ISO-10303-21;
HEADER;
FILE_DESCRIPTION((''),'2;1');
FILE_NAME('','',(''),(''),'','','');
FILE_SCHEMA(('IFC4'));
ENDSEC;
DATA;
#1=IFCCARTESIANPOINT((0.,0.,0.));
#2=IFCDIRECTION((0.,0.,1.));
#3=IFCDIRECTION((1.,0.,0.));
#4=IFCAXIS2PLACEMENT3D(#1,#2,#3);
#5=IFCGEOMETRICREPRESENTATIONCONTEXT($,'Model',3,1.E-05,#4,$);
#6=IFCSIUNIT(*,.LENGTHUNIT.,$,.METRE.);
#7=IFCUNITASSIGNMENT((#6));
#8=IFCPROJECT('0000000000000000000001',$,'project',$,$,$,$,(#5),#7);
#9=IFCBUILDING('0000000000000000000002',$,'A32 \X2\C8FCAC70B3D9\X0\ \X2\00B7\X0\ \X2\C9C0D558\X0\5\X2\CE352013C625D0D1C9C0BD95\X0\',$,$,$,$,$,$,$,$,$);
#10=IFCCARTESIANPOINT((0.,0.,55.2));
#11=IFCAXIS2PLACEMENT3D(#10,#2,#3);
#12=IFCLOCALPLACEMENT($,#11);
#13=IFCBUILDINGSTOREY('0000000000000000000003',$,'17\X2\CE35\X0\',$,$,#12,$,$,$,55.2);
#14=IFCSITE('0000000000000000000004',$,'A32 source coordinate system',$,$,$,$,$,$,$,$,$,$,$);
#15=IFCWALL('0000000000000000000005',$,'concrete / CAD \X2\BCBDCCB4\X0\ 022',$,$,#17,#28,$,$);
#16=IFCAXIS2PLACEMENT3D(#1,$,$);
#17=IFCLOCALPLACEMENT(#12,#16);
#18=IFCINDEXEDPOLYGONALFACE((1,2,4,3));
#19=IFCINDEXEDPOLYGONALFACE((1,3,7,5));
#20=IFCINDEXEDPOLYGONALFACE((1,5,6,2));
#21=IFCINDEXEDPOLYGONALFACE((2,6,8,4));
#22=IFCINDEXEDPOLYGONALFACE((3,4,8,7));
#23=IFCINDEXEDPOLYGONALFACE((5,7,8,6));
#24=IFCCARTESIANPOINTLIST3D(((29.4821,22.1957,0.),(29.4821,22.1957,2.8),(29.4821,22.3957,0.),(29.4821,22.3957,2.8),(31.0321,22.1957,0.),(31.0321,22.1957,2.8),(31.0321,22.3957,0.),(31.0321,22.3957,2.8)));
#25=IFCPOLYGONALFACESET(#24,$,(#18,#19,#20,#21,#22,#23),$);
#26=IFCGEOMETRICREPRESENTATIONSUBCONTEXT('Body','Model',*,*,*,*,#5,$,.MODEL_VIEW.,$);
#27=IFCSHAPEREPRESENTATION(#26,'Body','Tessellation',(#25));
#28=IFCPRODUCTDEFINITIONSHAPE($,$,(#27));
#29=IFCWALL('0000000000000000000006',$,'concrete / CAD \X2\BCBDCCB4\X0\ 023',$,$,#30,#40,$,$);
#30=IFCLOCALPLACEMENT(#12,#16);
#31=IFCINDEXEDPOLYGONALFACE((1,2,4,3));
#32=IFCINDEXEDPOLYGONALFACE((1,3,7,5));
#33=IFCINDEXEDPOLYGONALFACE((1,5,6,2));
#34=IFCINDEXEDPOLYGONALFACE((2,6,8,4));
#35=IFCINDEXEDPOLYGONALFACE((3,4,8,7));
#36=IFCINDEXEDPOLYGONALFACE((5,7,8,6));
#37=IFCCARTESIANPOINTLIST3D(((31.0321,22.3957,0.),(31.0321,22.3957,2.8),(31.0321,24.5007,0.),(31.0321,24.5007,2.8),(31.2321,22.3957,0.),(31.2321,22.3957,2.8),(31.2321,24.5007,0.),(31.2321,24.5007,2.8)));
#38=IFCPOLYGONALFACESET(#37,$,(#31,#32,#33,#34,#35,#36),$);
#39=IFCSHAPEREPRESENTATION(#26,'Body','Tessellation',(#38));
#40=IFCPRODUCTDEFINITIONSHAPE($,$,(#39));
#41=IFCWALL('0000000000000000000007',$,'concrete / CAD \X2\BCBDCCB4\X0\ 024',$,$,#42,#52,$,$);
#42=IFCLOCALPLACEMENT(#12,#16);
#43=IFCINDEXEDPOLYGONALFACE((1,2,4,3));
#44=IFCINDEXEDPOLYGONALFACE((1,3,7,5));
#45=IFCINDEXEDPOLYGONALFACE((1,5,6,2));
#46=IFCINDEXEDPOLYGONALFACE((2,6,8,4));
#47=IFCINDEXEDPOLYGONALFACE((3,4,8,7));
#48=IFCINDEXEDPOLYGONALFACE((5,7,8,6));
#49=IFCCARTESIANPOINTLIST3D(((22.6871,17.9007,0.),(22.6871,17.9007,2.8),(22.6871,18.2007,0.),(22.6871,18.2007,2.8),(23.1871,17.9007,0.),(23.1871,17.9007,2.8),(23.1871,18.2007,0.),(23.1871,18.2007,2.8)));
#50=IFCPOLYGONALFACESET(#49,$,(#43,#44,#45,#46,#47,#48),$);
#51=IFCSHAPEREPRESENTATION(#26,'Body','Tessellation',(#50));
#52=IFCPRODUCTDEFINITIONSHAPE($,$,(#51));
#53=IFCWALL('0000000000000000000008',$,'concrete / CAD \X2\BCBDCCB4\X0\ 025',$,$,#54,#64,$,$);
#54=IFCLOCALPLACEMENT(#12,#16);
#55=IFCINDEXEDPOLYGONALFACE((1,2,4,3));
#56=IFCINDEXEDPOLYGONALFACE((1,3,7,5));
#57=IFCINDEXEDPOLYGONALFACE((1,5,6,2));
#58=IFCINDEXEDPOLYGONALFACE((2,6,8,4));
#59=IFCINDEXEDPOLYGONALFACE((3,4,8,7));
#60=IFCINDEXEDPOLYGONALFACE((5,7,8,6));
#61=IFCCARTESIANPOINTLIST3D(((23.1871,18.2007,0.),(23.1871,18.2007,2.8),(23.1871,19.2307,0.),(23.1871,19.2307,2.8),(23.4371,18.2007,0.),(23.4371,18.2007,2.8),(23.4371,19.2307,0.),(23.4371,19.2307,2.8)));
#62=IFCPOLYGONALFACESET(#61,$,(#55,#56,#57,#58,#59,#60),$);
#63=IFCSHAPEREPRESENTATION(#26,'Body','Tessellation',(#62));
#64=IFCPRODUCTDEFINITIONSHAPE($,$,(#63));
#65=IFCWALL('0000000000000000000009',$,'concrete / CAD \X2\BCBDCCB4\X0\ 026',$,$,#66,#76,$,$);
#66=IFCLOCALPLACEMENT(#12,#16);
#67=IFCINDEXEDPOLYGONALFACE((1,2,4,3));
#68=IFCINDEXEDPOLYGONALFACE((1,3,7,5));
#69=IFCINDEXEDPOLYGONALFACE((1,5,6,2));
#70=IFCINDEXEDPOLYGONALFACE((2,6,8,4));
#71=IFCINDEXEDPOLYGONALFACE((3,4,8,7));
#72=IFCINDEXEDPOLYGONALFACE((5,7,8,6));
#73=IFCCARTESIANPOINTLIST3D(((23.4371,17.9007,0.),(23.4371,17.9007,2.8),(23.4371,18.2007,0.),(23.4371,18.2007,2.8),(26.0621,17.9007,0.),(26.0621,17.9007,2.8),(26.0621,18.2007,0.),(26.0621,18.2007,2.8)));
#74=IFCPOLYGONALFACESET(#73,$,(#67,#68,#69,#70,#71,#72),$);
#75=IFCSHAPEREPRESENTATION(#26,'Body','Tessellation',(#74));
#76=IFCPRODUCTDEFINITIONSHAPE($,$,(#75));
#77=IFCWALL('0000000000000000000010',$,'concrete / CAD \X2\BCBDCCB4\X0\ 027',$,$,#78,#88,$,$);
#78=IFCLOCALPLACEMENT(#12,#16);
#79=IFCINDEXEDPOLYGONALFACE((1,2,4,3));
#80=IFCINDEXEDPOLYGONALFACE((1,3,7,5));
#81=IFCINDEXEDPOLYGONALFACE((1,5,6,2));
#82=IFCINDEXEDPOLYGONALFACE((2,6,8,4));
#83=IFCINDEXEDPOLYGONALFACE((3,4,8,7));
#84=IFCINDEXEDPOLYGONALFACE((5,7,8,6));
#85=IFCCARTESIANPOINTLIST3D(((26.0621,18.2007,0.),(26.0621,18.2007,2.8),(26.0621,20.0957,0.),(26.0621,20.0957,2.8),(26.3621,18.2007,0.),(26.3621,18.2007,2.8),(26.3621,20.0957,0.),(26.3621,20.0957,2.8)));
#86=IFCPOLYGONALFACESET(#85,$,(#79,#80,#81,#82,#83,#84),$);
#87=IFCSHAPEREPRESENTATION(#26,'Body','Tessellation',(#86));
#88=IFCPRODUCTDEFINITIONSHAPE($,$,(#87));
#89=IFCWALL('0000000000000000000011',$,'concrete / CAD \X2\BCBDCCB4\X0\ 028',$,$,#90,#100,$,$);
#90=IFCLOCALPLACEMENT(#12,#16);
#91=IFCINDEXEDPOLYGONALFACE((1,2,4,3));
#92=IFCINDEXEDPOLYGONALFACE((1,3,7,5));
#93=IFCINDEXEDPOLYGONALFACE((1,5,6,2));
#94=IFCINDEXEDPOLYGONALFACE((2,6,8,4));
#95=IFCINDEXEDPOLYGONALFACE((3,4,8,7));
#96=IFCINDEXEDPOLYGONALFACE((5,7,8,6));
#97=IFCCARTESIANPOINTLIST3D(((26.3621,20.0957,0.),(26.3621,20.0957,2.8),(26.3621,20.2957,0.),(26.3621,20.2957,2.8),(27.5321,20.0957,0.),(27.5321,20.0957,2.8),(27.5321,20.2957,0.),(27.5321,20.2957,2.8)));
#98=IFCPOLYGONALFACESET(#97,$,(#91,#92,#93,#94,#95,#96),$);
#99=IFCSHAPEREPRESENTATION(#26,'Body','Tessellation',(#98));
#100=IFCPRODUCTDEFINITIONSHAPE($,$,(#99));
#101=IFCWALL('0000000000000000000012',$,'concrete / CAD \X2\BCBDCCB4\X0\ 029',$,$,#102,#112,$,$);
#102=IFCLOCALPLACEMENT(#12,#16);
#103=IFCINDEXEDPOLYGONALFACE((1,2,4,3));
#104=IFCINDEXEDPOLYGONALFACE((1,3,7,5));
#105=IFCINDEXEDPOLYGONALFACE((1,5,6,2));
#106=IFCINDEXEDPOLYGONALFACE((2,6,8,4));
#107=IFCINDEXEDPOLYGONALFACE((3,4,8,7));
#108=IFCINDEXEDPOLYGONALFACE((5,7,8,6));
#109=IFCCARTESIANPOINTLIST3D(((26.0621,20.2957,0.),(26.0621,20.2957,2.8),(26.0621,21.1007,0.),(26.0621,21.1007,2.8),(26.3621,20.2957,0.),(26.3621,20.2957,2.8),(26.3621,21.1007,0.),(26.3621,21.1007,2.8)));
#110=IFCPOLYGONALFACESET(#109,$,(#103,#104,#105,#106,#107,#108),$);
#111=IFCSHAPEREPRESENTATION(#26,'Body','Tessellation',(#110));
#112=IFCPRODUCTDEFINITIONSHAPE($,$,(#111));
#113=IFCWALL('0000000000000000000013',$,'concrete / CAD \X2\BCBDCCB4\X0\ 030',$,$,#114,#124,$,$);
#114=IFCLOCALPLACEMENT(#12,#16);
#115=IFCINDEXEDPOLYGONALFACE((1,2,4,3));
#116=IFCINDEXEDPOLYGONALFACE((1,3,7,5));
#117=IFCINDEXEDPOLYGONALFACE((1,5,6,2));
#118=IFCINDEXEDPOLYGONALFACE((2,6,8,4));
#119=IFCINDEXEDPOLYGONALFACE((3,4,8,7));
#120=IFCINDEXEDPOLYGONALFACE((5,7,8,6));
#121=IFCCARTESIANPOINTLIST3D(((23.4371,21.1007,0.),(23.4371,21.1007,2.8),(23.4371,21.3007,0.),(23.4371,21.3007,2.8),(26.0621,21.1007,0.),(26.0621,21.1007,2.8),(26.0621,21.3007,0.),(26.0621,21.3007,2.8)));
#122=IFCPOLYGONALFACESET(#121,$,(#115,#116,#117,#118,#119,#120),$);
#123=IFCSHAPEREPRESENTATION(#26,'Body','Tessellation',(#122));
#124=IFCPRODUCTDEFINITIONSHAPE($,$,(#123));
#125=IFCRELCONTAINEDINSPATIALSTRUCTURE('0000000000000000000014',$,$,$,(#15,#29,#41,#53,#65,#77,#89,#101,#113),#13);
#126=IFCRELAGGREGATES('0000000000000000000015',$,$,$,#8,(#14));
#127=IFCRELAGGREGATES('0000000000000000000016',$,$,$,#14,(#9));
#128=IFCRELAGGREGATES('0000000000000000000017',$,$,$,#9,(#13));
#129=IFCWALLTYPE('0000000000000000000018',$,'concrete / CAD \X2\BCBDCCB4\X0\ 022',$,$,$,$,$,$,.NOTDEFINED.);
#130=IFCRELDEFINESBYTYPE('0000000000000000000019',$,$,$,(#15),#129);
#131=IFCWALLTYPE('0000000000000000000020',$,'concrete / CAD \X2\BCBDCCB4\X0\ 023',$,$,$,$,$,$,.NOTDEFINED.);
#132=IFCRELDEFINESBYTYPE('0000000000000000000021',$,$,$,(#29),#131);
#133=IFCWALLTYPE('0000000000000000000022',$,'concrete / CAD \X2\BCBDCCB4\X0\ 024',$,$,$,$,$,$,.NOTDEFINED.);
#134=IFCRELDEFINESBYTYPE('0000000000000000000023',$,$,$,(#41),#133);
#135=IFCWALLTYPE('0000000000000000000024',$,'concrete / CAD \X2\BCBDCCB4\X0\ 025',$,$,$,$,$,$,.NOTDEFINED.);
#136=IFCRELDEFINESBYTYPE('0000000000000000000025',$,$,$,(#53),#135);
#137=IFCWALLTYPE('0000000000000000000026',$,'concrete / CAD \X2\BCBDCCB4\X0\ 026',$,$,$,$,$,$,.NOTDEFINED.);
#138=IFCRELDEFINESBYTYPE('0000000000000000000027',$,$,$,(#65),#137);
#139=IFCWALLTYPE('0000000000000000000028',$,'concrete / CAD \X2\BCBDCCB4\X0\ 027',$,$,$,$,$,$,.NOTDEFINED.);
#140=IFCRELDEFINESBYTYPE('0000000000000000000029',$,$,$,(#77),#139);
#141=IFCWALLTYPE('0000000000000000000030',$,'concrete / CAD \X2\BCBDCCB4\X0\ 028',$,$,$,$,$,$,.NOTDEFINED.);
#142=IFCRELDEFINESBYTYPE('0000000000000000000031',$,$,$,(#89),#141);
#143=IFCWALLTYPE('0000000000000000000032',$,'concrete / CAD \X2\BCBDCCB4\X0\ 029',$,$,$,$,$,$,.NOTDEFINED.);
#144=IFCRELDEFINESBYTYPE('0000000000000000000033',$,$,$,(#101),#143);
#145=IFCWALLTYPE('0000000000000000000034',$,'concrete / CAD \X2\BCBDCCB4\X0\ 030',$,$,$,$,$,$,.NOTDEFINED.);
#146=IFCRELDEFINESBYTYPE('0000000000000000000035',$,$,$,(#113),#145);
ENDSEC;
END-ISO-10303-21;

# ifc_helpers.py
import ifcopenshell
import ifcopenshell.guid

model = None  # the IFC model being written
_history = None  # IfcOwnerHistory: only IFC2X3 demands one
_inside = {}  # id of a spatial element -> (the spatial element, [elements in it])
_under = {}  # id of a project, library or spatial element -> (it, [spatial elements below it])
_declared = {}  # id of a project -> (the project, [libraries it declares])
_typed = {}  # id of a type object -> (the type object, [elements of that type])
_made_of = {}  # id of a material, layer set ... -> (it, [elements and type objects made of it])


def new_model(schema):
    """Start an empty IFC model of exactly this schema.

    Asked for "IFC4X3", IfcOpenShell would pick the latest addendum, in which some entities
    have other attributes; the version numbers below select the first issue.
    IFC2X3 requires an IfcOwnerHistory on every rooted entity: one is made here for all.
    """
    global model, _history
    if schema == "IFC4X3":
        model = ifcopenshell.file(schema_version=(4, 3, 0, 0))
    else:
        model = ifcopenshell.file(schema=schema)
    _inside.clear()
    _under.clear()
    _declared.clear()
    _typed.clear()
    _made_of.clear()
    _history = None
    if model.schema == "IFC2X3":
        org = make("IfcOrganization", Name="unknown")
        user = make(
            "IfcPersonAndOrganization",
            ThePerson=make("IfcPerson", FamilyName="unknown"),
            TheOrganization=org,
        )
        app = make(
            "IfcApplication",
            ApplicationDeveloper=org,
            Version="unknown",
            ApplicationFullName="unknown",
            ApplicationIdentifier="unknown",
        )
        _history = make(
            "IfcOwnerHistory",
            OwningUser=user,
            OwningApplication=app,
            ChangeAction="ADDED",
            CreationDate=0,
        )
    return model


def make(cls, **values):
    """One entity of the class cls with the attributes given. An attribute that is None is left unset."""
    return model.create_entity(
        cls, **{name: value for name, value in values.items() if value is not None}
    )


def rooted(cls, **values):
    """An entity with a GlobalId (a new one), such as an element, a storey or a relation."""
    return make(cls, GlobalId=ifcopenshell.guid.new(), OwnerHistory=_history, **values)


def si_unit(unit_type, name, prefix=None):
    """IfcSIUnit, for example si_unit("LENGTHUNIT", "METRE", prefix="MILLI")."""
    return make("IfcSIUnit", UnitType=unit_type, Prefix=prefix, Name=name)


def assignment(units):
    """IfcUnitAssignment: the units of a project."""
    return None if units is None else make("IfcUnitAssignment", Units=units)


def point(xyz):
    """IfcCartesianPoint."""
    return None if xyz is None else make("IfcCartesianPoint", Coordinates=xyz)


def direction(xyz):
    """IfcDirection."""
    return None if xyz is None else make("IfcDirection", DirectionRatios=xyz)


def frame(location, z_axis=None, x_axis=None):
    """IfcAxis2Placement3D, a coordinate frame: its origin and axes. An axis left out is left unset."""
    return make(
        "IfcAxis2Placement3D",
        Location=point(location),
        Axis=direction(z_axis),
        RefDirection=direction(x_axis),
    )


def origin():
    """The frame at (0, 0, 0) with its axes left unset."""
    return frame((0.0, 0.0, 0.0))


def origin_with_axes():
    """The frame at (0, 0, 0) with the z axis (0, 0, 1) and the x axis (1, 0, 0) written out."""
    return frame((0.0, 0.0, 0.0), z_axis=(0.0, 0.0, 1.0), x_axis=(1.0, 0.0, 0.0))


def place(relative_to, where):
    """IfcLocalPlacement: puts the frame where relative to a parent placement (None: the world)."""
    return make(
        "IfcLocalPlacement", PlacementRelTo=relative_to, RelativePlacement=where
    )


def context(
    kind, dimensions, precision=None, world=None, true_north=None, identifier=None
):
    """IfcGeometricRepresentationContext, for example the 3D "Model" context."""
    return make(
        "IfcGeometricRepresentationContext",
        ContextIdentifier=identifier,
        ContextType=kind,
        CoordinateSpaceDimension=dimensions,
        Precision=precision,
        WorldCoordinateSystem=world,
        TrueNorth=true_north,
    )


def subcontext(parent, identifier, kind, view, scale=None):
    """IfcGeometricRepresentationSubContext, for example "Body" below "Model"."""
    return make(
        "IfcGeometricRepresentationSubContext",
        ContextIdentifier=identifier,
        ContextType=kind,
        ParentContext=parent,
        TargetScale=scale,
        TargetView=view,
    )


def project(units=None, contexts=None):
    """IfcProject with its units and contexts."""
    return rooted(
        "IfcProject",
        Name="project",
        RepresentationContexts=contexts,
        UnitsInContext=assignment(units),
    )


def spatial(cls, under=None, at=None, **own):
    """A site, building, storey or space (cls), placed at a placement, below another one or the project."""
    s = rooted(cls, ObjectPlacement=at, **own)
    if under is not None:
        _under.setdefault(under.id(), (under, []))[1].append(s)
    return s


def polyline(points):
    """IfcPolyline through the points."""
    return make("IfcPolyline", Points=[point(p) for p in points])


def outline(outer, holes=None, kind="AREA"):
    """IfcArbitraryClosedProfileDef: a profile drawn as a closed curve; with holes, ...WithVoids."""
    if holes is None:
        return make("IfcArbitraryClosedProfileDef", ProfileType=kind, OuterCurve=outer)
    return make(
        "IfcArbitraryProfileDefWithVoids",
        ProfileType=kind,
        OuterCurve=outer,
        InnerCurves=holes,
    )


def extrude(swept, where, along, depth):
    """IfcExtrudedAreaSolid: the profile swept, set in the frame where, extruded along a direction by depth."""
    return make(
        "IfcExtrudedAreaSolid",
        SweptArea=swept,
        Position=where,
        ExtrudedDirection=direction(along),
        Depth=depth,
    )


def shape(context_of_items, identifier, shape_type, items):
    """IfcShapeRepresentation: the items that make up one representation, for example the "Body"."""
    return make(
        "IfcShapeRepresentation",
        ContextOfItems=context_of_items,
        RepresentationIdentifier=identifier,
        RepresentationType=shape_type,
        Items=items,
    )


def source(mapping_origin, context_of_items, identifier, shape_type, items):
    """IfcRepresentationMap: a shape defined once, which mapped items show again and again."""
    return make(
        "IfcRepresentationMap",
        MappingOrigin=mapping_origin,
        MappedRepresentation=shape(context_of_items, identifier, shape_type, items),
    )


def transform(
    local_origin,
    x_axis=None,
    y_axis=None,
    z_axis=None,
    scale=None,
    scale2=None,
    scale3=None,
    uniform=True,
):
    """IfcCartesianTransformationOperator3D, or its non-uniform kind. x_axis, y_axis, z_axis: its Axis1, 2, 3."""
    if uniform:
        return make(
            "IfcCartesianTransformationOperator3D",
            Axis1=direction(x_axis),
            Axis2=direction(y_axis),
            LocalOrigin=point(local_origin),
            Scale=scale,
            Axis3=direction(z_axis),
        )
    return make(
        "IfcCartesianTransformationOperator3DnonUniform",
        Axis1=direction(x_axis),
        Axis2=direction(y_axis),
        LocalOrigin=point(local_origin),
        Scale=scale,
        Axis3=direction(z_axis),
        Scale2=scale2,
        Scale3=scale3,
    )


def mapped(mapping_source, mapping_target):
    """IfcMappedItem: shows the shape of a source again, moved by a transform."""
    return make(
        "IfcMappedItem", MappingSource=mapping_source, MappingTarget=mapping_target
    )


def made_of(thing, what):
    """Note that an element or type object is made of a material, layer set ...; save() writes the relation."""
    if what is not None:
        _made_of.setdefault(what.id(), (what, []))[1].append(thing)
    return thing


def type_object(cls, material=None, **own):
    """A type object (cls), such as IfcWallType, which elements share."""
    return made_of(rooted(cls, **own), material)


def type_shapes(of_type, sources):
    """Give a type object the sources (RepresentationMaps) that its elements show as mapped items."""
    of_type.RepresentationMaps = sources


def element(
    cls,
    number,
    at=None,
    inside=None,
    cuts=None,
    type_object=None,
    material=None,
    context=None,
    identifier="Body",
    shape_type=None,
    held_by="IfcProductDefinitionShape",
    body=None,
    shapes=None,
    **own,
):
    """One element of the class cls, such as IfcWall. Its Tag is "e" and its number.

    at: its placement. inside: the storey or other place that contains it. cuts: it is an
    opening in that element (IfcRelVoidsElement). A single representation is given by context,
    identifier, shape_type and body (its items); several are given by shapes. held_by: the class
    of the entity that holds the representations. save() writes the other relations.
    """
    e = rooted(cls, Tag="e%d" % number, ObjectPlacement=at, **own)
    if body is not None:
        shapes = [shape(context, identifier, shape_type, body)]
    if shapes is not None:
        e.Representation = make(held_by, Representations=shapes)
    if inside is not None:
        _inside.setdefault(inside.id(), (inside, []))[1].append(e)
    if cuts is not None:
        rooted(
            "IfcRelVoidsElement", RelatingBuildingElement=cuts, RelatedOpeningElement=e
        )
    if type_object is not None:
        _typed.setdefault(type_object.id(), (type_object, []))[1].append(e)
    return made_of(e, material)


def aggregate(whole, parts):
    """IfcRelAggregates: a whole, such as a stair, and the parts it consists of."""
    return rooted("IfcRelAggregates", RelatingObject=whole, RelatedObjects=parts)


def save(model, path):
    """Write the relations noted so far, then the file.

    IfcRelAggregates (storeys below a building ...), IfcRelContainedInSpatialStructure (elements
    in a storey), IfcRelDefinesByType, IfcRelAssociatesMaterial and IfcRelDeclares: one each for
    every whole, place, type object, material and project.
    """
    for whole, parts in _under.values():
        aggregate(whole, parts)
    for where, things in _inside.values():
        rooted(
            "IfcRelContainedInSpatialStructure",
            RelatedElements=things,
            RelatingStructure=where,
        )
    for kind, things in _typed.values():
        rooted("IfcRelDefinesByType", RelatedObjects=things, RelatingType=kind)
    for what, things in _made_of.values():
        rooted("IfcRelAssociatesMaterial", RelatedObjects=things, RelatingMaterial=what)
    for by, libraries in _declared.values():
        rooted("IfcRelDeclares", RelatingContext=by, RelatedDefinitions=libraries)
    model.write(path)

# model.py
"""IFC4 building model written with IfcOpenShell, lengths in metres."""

from ifc_helpers import new_model, si_unit, frame, origin, origin_with_axes, place, context, subcontext, project, spatial, polyline, outline, extrude, source, transform, mapped, type_object, type_shapes, element, save


model = new_model("IFC4")

# Units and contexts
model_context = context("Model", 3, precision=1e-05, world=origin_with_axes())
body_context = subcontext(model_context, "Body", "Model", "MODEL_VIEW")
ifc_project = project(units=[si_unit("LENGTHUNIT", "METRE")], contexts=[model_context])

# Site, building, storey
site = spatial("IfcSite", under=ifc_project, Name="A32 source coordinate system")
building = spatial("IfcBuilding", under=site, Name="A32 주거동 · 지하5층–옥탑지붕")
storey_placement = place(None, frame((0.0, 0.0, 55.2), z_axis=(0.0, 0.0, 1.0), x_axis=(1.0, 0.0, 0.0)))
storey = spatial("IfcBuildingStorey", under=building, at=storey_placement, Name="17층", Elevation=55.2)

# Walls
wall_type_1 = type_object("IfcWallType", Name="concrete / CAD 벽체 022", PredefinedType="NOTDEFINED")
shared_shape_1 = source(origin(), body_context, "Body", "SweptSolid", [
    extrude(outline(polyline([(31.0321, 22.1957), (29.4821, 22.1957), (29.4821, 22.3957), (31.0321, 22.3957), (31.0321, 22.1957)])), origin(), (0.0, 0.0, 1.0), 2.8),
])
type_shapes(wall_type_1, [shared_shape_1])
wall_1_placement = place(storey_placement, origin_with_axes())
element("IfcWall", 1, at=wall_1_placement, inside=storey, type_object=wall_type_1, Name="concrete / CAD 벽체 022", context=body_context, shape_type="MappedRepresentation", body=[
    mapped(shared_shape_1, transform((0.0, 0.0, 0.0), scale=1.0)),
])
wall_type_2 = type_object("IfcWallType", Name="concrete / CAD 벽체 023", PredefinedType="NOTDEFINED")
shared_shape_2 = source(origin(), body_context, "Body", "SweptSolid", [
    extrude(outline(polyline([(31.2321, 24.5007), (31.2321, 22.3957), (31.0321, 22.3957), (31.0321, 24.5007), (31.2321, 24.5007)])), origin(), (0.0, 0.0, 1.0), 2.8),
])
type_shapes(wall_type_2, [shared_shape_2])
wall_2_placement = place(storey_placement, origin_with_axes())
element("IfcWall", 2, at=wall_2_placement, inside=storey, type_object=wall_type_2, Name="concrete / CAD 벽체 023", context=body_context, shape_type="MappedRepresentation", body=[
    mapped(shared_shape_2, transform((0.0, 0.0, 0.0), scale=1.0)),
])
wall_type_3 = type_object("IfcWallType", Name="concrete / CAD 벽체 024", PredefinedType="NOTDEFINED")
shared_shape_3 = source(origin(), body_context, "Body", "SweptSolid", [
    extrude(outline(polyline([(23.1871, 17.9007), (22.6871, 17.9007), (22.6871, 18.2007), (23.1871, 18.2007), (23.1871, 17.9007)])), origin(), (0.0, 0.0, 1.0), 2.8),
])
type_shapes(wall_type_3, [shared_shape_3])
wall_3_placement = place(storey_placement, origin_with_axes())
element("IfcWall", 3, at=wall_3_placement, inside=storey, type_object=wall_type_3, Name="concrete / CAD 벽체 024", context=body_context, shape_type="MappedRepresentation", body=[
    mapped(shared_shape_3, transform((0.0, 0.0, 0.0), scale=1.0)),
])
wall_type_4 = type_object("IfcWallType", Name="concrete / CAD 벽체 025", PredefinedType="NOTDEFINED")
shared_shape_4 = source(origin(), body_context, "Body", "SweptSolid", [
    extrude(outline(polyline([(23.4371, 19.2307), (23.4371, 18.2007), (23.1871, 18.2007), (23.1871, 19.2307), (23.4371, 19.2307)])), origin(), (0.0, 0.0, 1.0), 2.8),
])
type_shapes(wall_type_4, [shared_shape_4])
wall_4_placement = place(storey_placement, origin_with_axes())
element("IfcWall", 4, at=wall_4_placement, inside=storey, type_object=wall_type_4, Name="concrete / CAD 벽체 025", context=body_context, shape_type="MappedRepresentation", body=[
    mapped(shared_shape_4, transform((0.0, 0.0, 0.0), scale=1.0)),
])
wall_type_5 = type_object("IfcWallType", Name="concrete / CAD 벽체 026", PredefinedType="NOTDEFINED")
shared_shape_5 = source(origin(), body_context, "Body", "SweptSolid", [
    extrude(outline(polyline([(26.0621, 17.9007), (23.4371, 17.9007), (23.4371, 18.2007), (26.0621, 18.2007), (26.0621, 17.9007)])), origin(), (0.0, 0.0, 1.0), 2.8),
])
type_shapes(wall_type_5, [shared_shape_5])
wall_5_placement = place(storey_placement, origin_with_axes())
element("IfcWall", 5, at=wall_5_placement, inside=storey, type_object=wall_type_5, Name="concrete / CAD 벽체 026", context=body_context, shape_type="MappedRepresentation", body=[
    mapped(shared_shape_5, transform((0.0, 0.0, 0.0), scale=1.0)),
])
wall_type_6 = type_object("IfcWallType", Name="concrete / CAD 벽체 027", PredefinedType="NOTDEFINED")
shared_shape_6 = source(origin(), body_context, "Body", "SweptSolid", [
    extrude(outline(polyline([(26.3621, 20.0957), (26.3621, 18.2007), (26.0621, 18.2007), (26.0621, 20.0957), (26.3621, 20.0957)])), origin(), (0.0, 0.0, 1.0), 2.8),
])
type_shapes(wall_type_6, [shared_shape_6])
wall_6_placement = place(storey_placement, origin_with_axes())
element("IfcWall", 6, at=wall_6_placement, inside=storey, type_object=wall_type_6, Name="concrete / CAD 벽체 027", context=body_context, shape_type="MappedRepresentation", body=[
    mapped(shared_shape_6, transform((0.0, 0.0, 0.0), scale=1.0)),
])
wall_type_7 = type_object("IfcWallType", Name="concrete / CAD 벽체 028", PredefinedType="NOTDEFINED")
shared_shape_7 = source(origin(), body_context, "Body", "SweptSolid", [
    extrude(outline(polyline([(27.5321, 20.0957), (26.3621, 20.0957), (26.3621, 20.2957), (27.5321, 20.2957), (27.5321, 20.0957)])), origin(), (0.0, 0.0, 1.0), 2.8),
])
type_shapes(wall_type_7, [shared_shape_7])
wall_7_placement = place(storey_placement, origin_with_axes())
element("IfcWall", 7, at=wall_7_placement, inside=storey, type_object=wall_type_7, Name="concrete / CAD 벽체 028", context=body_context, shape_type="MappedRepresentation", body=[
    mapped(shared_shape_7, transform((0.0, 0.0, 0.0), scale=1.0)),
])
wall_type_8 = type_object("IfcWallType", Name="concrete / CAD 벽체 029", PredefinedType="NOTDEFINED")
shared_shape_8 = source(origin(), body_context, "Body", "SweptSolid", [
    extrude(outline(polyline([(26.3621, 21.1007), (26.3621, 20.2957), (26.0621, 20.2957), (26.0621, 21.1007), (26.3621, 21.1007)])), origin(), (0.0, 0.0, 1.0), 2.8),
])
type_shapes(wall_type_8, [shared_shape_8])
wall_8_placement = place(storey_placement, origin_with_axes())
element("IfcWall", 8, at=wall_8_placement, inside=storey, type_object=wall_type_8, Name="concrete / CAD 벽체 029", context=body_context, shape_type="MappedRepresentation", body=[
    mapped(shared_shape_8, transform((0.0, 0.0, 0.0), scale=1.0)),
])
wall_type_9 = type_object("IfcWallType", Name="concrete / CAD 벽체 030", PredefinedType="NOTDEFINED")
shared_shape_9 = source(origin(), body_context, "Body", "SweptSolid", [
    extrude(outline(polyline([(23.4371, 21.3007), (26.0621, 21.3007), (26.0621, 21.1007), (23.4371, 21.1007), (23.4371, 21.3007)])), origin(), (0.0, 0.0, 1.0), 2.8),
])
type_shapes(wall_type_9, [shared_shape_9])
wall_9_placement = place(storey_placement, origin_with_axes())
element("IfcWall", 9, at=wall_9_placement, inside=storey, type_object=wall_type_9, Name="concrete / CAD 벽체 030", context=body_context, shape_type="MappedRepresentation", body=[
    mapped(shared_shape_9, transform((0.0, 0.0, 0.0), scale=1.0)),
])

save(model, "model.ifc")
